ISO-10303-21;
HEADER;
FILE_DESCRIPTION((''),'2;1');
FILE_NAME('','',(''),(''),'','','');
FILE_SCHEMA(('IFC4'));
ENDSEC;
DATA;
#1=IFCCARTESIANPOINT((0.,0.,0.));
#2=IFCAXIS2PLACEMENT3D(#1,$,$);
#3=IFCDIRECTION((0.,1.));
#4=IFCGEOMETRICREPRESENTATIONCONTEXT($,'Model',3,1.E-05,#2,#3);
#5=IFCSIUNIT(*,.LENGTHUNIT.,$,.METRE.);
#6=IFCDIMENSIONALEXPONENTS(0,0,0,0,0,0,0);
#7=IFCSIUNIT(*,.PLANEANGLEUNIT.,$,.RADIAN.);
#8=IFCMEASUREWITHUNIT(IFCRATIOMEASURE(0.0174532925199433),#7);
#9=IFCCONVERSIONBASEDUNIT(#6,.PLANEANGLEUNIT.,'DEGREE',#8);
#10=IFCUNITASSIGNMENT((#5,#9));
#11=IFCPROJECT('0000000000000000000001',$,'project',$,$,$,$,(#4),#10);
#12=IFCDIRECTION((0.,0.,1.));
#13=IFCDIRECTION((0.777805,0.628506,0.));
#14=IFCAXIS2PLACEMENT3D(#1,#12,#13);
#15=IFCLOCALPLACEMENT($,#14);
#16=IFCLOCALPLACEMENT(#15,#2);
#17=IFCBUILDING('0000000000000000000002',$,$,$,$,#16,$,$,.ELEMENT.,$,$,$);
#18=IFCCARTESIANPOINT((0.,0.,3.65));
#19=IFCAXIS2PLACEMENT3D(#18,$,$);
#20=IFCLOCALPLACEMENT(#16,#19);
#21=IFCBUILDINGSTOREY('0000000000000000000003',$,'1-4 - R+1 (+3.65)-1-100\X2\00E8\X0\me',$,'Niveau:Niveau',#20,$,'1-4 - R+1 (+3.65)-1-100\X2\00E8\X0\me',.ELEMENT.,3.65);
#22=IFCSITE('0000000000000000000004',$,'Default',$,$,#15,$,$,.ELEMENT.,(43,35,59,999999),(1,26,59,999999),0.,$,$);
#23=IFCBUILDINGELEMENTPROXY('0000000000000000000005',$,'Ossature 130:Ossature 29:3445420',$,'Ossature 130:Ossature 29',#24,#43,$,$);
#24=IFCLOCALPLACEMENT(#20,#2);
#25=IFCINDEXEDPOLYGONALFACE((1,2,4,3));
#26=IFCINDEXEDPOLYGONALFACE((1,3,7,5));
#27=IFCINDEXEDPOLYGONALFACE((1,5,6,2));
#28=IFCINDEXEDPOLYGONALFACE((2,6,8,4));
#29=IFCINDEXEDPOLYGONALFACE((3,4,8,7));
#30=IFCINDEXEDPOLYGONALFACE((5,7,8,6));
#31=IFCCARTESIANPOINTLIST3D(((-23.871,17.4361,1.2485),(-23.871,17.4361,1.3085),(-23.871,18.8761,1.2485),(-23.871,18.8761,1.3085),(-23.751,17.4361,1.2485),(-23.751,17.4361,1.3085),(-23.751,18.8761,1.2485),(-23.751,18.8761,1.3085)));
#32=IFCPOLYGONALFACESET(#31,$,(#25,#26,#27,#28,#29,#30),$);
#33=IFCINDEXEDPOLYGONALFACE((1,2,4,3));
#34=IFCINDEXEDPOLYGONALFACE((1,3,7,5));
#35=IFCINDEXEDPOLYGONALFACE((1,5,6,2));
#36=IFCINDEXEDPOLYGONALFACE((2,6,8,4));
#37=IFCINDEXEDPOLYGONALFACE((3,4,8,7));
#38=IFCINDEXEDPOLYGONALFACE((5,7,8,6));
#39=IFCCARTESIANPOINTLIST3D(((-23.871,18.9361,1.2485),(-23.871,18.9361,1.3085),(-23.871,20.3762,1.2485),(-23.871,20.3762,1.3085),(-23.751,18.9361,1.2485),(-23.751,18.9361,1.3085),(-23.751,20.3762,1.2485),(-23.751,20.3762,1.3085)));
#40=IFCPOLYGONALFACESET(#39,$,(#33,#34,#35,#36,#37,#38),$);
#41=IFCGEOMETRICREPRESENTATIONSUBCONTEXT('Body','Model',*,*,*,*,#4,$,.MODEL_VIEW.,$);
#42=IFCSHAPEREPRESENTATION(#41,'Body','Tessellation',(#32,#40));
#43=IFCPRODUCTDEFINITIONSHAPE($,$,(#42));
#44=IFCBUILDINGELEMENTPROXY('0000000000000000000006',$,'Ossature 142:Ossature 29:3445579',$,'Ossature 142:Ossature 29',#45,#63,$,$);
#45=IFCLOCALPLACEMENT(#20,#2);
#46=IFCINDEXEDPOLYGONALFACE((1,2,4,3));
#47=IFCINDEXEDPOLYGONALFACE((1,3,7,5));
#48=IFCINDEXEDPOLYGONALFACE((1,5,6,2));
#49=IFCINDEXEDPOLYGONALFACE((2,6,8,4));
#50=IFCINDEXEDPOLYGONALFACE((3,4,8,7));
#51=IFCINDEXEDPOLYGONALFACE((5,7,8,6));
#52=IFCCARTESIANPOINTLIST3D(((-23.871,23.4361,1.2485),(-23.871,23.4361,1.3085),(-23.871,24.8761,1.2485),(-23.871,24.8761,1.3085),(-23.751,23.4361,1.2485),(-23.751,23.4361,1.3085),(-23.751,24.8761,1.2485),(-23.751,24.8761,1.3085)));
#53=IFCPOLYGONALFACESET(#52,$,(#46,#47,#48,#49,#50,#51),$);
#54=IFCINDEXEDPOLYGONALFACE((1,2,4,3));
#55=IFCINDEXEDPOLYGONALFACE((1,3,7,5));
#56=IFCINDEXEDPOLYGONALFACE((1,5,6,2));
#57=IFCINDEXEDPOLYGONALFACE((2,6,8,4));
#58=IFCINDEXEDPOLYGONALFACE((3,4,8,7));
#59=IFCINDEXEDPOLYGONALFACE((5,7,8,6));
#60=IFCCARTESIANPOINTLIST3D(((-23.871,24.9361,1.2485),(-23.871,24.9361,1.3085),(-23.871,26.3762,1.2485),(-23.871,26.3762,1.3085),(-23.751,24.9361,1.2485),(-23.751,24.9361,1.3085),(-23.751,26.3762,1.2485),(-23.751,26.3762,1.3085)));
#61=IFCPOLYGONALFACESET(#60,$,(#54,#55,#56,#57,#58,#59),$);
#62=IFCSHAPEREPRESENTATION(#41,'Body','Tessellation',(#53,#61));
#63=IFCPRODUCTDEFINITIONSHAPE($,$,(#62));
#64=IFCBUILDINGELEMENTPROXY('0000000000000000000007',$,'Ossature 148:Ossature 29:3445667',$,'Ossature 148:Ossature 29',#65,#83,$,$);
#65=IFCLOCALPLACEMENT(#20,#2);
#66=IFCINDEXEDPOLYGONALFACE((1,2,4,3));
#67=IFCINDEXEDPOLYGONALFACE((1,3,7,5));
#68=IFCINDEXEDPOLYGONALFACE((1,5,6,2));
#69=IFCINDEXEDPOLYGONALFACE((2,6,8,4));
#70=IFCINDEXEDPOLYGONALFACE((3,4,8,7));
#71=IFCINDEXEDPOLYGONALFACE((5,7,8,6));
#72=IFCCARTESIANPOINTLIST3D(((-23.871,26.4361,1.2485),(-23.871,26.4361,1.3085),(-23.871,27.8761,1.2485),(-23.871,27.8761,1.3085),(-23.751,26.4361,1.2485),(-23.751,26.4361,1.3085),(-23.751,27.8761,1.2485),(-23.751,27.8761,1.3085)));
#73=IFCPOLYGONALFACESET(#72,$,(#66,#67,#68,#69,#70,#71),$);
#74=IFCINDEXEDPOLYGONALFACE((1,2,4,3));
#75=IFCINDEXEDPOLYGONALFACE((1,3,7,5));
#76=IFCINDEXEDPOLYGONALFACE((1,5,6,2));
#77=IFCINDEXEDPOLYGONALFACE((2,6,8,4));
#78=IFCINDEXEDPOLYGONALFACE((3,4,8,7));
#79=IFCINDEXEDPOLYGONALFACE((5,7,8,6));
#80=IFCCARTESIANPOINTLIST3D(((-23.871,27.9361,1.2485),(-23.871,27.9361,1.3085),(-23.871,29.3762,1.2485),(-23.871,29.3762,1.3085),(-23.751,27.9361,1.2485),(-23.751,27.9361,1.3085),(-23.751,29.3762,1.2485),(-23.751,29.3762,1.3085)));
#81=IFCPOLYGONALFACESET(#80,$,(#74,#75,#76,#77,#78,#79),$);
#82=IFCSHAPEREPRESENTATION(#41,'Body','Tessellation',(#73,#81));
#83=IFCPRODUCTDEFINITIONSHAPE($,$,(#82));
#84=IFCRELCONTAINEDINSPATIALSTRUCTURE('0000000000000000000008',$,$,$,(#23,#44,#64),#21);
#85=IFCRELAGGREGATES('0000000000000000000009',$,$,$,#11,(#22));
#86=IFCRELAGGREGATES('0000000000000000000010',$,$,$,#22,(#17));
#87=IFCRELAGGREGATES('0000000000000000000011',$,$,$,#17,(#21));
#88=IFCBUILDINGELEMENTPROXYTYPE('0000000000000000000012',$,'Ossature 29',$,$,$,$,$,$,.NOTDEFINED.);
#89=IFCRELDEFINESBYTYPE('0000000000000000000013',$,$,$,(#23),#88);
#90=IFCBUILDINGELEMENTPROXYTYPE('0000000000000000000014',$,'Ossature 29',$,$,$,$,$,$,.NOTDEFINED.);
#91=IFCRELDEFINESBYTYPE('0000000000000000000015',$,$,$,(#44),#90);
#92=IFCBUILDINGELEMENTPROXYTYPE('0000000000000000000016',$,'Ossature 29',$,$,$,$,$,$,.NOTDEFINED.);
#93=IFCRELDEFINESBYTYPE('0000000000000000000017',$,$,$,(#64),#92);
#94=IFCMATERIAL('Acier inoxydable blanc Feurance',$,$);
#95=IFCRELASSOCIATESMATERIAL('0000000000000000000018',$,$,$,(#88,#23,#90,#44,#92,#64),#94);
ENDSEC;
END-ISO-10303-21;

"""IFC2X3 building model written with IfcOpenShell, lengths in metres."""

from ifc_helpers import new_model, entity, si_unit, converted_unit, direction, frame, frame_2d, origin, place, context, subcontext, project, spatial, rectangle, extrude, source, transform, mapped, material, type_object, type_shapes, element, save


model = new_model("IFC2X3")

# Units and contexts
model_context = context("Model", 3, precision=1e-05, world=origin(), true_north=direction((0.0, 1.0)))
body_context = subcontext(model_context, "Body", "Model", "MODEL_VIEW")
ifc_project = project(units=[si_unit("LENGTHUNIT", "METRE"), converted_unit("PLANEANGLEUNIT", "DEGREE", entity("IfcRatioMeasure", 0.0174532925199433), si_unit("PLANEANGLEUNIT", "RADIAN"), dimensions=[0, 0, 0, 0, 0, 0, 0])], contexts=[model_context])

# Site, building, storey
site_placement = place(None, frame((0.0, 0.0, 0.0), z_axis=(0.0, 0.0, 1.0), x_axis=(0.777805, 0.628506, 0.0)))
site = spatial("IfcSite", under=ifc_project, at=site_placement, Name="Default", CompositionType="ELEMENT", RefLatitude=(43, 35, 59, 999999), RefLongitude=(1, 26, 59, 999999), RefElevation=0.0)
building_placement = place(site_placement, origin())
building = spatial("IfcBuilding", under=site, at=building_placement, CompositionType="ELEMENT")
storey_placement = place(building_placement, frame((0.0, 0.0, 3.65)))
storey = spatial("IfcBuildingStorey", under=building, at=storey_placement, Name="1-4 - R+1 (+3.65)-1-100ème", ObjectType="Niveau:Niveau", LongName="1-4 - R+1 (+3.65)-1-100ème", CompositionType="ELEMENT", Elevation=3.65)

# Building element proxies
ifc_material_1 = material(Name="Acier inoxydable blanc Feurance")
building_element_proxy_type_1 = type_object("IfcBuildingElementProxyType", Name="Ossature 29", PredefinedType="NOTDEFINED", material=ifc_material_1)
shared_shape_1 = source(origin(), body_context, "Body", "SweptSolid", [
    extrude(rectangle(XDim=1.44, YDim=0.12, at=frame_2d((0.0, 0.0), x_axis=(1.0, 0.0))), frame((-23.811, 18.1561, 4.67), z_axis=(0.0, 0.0, 1.0), x_axis=(0.0, -1.0, 0.0)), (0.0, 0.0, 1.0), 0.06),
    extrude(rectangle(XDim=1.44, YDim=0.12, at=frame_2d((0.0, 0.0), x_axis=(1.0, 0.0))), frame((-23.811, 19.6561, 4.67), z_axis=(0.0, 0.0, 1.0), x_axis=(0.0, -1.0, 0.0)), (0.0, 0.0, 1.0), 0.06),
])
type_shapes(building_element_proxy_type_1, [shared_shape_1])
proxy_1_placement = place(storey_placement, frame((0.0, 0.0, -3.4215)))
element("IfcBuildingElementProxy", 1, at=proxy_1_placement, inside=storey, type_object=building_element_proxy_type_1, material=ifc_material_1, Name="Ossature 130:Ossature 29:3445420", ObjectType="Ossature 130:Ossature 29", context=body_context, shape_type="MappedRepresentation", body=[
    mapped(shared_shape_1, transform((0.0, 0.0, 0.0), scale=1.0)),
])
building_element_proxy_type_2 = type_object("IfcBuildingElementProxyType", Name="Ossature 29", PredefinedType="NOTDEFINED", material=ifc_material_1)
shared_shape_2 = source(origin(), body_context, "Body", "SweptSolid", [
    extrude(rectangle(XDim=1.44, YDim=0.12, at=frame_2d((0.0, 0.0), x_axis=(1.0, 0.0))), frame((-23.811, 24.1561, 4.67), z_axis=(0.0, 0.0, 1.0), x_axis=(0.0, -1.0, 0.0)), (0.0, 0.0, 1.0), 0.06),
    extrude(rectangle(XDim=1.44, YDim=0.12, at=frame_2d((0.0, 0.0), x_axis=(1.0, 0.0))), frame((-23.811, 25.6561, 4.67), z_axis=(0.0, 0.0, 1.0), x_axis=(0.0, -1.0, 0.0)), (0.0, 0.0, 1.0), 0.06),
])
type_shapes(building_element_proxy_type_2, [shared_shape_2])
proxy_2_placement = place(storey_placement, frame((0.0, 0.0, -3.4215)))
element("IfcBuildingElementProxy", 2, at=proxy_2_placement, inside=storey, type_object=building_element_proxy_type_2, material=ifc_material_1, Name="Ossature 142:Ossature 29:3445579", ObjectType="Ossature 142:Ossature 29", context=body_context, shape_type="MappedRepresentation", body=[
    mapped(shared_shape_2, transform((0.0, 0.0, 0.0), scale=1.0)),
])
building_element_proxy_type_3 = type_object("IfcBuildingElementProxyType", Name="Ossature 29", PredefinedType="NOTDEFINED", material=ifc_material_1)
shared_shape_3 = source(origin(), body_context, "Body", "SweptSolid", [
    extrude(rectangle(XDim=1.44, YDim=0.12, at=frame_2d((0.0, 0.0), x_axis=(1.0, 0.0))), frame((-23.811, 27.1561, 4.67), z_axis=(0.0, 0.0, 1.0), x_axis=(0.0, -1.0, 0.0)), (0.0, 0.0, 1.0), 0.06),
    extrude(rectangle(XDim=1.44, YDim=0.12, at=frame_2d((0.0, 0.0), x_axis=(1.0, 0.0))), frame((-23.811, 28.6561, 4.67), z_axis=(0.0, 0.0, 1.0), x_axis=(0.0, -1.0, 0.0)), (0.0, 0.0, 1.0), 0.06),
])
type_shapes(building_element_proxy_type_3, [shared_shape_3])
proxy_3_placement = place(storey_placement, frame((0.0, 0.0, -3.4215)))
element("IfcBuildingElementProxy", 3, at=proxy_3_placement, inside=storey, type_object=building_element_proxy_type_3, material=ifc_material_1, Name="Ossature 148:Ossature 29:3445667", ObjectType="Ossature 148:Ossature 29", context=body_context, shape_type="MappedRepresentation", body=[
    mapped(shared_shape_3, transform((0.0, 0.0, 0.0), scale=1.0)),
])

save(model, "model.ifc")
